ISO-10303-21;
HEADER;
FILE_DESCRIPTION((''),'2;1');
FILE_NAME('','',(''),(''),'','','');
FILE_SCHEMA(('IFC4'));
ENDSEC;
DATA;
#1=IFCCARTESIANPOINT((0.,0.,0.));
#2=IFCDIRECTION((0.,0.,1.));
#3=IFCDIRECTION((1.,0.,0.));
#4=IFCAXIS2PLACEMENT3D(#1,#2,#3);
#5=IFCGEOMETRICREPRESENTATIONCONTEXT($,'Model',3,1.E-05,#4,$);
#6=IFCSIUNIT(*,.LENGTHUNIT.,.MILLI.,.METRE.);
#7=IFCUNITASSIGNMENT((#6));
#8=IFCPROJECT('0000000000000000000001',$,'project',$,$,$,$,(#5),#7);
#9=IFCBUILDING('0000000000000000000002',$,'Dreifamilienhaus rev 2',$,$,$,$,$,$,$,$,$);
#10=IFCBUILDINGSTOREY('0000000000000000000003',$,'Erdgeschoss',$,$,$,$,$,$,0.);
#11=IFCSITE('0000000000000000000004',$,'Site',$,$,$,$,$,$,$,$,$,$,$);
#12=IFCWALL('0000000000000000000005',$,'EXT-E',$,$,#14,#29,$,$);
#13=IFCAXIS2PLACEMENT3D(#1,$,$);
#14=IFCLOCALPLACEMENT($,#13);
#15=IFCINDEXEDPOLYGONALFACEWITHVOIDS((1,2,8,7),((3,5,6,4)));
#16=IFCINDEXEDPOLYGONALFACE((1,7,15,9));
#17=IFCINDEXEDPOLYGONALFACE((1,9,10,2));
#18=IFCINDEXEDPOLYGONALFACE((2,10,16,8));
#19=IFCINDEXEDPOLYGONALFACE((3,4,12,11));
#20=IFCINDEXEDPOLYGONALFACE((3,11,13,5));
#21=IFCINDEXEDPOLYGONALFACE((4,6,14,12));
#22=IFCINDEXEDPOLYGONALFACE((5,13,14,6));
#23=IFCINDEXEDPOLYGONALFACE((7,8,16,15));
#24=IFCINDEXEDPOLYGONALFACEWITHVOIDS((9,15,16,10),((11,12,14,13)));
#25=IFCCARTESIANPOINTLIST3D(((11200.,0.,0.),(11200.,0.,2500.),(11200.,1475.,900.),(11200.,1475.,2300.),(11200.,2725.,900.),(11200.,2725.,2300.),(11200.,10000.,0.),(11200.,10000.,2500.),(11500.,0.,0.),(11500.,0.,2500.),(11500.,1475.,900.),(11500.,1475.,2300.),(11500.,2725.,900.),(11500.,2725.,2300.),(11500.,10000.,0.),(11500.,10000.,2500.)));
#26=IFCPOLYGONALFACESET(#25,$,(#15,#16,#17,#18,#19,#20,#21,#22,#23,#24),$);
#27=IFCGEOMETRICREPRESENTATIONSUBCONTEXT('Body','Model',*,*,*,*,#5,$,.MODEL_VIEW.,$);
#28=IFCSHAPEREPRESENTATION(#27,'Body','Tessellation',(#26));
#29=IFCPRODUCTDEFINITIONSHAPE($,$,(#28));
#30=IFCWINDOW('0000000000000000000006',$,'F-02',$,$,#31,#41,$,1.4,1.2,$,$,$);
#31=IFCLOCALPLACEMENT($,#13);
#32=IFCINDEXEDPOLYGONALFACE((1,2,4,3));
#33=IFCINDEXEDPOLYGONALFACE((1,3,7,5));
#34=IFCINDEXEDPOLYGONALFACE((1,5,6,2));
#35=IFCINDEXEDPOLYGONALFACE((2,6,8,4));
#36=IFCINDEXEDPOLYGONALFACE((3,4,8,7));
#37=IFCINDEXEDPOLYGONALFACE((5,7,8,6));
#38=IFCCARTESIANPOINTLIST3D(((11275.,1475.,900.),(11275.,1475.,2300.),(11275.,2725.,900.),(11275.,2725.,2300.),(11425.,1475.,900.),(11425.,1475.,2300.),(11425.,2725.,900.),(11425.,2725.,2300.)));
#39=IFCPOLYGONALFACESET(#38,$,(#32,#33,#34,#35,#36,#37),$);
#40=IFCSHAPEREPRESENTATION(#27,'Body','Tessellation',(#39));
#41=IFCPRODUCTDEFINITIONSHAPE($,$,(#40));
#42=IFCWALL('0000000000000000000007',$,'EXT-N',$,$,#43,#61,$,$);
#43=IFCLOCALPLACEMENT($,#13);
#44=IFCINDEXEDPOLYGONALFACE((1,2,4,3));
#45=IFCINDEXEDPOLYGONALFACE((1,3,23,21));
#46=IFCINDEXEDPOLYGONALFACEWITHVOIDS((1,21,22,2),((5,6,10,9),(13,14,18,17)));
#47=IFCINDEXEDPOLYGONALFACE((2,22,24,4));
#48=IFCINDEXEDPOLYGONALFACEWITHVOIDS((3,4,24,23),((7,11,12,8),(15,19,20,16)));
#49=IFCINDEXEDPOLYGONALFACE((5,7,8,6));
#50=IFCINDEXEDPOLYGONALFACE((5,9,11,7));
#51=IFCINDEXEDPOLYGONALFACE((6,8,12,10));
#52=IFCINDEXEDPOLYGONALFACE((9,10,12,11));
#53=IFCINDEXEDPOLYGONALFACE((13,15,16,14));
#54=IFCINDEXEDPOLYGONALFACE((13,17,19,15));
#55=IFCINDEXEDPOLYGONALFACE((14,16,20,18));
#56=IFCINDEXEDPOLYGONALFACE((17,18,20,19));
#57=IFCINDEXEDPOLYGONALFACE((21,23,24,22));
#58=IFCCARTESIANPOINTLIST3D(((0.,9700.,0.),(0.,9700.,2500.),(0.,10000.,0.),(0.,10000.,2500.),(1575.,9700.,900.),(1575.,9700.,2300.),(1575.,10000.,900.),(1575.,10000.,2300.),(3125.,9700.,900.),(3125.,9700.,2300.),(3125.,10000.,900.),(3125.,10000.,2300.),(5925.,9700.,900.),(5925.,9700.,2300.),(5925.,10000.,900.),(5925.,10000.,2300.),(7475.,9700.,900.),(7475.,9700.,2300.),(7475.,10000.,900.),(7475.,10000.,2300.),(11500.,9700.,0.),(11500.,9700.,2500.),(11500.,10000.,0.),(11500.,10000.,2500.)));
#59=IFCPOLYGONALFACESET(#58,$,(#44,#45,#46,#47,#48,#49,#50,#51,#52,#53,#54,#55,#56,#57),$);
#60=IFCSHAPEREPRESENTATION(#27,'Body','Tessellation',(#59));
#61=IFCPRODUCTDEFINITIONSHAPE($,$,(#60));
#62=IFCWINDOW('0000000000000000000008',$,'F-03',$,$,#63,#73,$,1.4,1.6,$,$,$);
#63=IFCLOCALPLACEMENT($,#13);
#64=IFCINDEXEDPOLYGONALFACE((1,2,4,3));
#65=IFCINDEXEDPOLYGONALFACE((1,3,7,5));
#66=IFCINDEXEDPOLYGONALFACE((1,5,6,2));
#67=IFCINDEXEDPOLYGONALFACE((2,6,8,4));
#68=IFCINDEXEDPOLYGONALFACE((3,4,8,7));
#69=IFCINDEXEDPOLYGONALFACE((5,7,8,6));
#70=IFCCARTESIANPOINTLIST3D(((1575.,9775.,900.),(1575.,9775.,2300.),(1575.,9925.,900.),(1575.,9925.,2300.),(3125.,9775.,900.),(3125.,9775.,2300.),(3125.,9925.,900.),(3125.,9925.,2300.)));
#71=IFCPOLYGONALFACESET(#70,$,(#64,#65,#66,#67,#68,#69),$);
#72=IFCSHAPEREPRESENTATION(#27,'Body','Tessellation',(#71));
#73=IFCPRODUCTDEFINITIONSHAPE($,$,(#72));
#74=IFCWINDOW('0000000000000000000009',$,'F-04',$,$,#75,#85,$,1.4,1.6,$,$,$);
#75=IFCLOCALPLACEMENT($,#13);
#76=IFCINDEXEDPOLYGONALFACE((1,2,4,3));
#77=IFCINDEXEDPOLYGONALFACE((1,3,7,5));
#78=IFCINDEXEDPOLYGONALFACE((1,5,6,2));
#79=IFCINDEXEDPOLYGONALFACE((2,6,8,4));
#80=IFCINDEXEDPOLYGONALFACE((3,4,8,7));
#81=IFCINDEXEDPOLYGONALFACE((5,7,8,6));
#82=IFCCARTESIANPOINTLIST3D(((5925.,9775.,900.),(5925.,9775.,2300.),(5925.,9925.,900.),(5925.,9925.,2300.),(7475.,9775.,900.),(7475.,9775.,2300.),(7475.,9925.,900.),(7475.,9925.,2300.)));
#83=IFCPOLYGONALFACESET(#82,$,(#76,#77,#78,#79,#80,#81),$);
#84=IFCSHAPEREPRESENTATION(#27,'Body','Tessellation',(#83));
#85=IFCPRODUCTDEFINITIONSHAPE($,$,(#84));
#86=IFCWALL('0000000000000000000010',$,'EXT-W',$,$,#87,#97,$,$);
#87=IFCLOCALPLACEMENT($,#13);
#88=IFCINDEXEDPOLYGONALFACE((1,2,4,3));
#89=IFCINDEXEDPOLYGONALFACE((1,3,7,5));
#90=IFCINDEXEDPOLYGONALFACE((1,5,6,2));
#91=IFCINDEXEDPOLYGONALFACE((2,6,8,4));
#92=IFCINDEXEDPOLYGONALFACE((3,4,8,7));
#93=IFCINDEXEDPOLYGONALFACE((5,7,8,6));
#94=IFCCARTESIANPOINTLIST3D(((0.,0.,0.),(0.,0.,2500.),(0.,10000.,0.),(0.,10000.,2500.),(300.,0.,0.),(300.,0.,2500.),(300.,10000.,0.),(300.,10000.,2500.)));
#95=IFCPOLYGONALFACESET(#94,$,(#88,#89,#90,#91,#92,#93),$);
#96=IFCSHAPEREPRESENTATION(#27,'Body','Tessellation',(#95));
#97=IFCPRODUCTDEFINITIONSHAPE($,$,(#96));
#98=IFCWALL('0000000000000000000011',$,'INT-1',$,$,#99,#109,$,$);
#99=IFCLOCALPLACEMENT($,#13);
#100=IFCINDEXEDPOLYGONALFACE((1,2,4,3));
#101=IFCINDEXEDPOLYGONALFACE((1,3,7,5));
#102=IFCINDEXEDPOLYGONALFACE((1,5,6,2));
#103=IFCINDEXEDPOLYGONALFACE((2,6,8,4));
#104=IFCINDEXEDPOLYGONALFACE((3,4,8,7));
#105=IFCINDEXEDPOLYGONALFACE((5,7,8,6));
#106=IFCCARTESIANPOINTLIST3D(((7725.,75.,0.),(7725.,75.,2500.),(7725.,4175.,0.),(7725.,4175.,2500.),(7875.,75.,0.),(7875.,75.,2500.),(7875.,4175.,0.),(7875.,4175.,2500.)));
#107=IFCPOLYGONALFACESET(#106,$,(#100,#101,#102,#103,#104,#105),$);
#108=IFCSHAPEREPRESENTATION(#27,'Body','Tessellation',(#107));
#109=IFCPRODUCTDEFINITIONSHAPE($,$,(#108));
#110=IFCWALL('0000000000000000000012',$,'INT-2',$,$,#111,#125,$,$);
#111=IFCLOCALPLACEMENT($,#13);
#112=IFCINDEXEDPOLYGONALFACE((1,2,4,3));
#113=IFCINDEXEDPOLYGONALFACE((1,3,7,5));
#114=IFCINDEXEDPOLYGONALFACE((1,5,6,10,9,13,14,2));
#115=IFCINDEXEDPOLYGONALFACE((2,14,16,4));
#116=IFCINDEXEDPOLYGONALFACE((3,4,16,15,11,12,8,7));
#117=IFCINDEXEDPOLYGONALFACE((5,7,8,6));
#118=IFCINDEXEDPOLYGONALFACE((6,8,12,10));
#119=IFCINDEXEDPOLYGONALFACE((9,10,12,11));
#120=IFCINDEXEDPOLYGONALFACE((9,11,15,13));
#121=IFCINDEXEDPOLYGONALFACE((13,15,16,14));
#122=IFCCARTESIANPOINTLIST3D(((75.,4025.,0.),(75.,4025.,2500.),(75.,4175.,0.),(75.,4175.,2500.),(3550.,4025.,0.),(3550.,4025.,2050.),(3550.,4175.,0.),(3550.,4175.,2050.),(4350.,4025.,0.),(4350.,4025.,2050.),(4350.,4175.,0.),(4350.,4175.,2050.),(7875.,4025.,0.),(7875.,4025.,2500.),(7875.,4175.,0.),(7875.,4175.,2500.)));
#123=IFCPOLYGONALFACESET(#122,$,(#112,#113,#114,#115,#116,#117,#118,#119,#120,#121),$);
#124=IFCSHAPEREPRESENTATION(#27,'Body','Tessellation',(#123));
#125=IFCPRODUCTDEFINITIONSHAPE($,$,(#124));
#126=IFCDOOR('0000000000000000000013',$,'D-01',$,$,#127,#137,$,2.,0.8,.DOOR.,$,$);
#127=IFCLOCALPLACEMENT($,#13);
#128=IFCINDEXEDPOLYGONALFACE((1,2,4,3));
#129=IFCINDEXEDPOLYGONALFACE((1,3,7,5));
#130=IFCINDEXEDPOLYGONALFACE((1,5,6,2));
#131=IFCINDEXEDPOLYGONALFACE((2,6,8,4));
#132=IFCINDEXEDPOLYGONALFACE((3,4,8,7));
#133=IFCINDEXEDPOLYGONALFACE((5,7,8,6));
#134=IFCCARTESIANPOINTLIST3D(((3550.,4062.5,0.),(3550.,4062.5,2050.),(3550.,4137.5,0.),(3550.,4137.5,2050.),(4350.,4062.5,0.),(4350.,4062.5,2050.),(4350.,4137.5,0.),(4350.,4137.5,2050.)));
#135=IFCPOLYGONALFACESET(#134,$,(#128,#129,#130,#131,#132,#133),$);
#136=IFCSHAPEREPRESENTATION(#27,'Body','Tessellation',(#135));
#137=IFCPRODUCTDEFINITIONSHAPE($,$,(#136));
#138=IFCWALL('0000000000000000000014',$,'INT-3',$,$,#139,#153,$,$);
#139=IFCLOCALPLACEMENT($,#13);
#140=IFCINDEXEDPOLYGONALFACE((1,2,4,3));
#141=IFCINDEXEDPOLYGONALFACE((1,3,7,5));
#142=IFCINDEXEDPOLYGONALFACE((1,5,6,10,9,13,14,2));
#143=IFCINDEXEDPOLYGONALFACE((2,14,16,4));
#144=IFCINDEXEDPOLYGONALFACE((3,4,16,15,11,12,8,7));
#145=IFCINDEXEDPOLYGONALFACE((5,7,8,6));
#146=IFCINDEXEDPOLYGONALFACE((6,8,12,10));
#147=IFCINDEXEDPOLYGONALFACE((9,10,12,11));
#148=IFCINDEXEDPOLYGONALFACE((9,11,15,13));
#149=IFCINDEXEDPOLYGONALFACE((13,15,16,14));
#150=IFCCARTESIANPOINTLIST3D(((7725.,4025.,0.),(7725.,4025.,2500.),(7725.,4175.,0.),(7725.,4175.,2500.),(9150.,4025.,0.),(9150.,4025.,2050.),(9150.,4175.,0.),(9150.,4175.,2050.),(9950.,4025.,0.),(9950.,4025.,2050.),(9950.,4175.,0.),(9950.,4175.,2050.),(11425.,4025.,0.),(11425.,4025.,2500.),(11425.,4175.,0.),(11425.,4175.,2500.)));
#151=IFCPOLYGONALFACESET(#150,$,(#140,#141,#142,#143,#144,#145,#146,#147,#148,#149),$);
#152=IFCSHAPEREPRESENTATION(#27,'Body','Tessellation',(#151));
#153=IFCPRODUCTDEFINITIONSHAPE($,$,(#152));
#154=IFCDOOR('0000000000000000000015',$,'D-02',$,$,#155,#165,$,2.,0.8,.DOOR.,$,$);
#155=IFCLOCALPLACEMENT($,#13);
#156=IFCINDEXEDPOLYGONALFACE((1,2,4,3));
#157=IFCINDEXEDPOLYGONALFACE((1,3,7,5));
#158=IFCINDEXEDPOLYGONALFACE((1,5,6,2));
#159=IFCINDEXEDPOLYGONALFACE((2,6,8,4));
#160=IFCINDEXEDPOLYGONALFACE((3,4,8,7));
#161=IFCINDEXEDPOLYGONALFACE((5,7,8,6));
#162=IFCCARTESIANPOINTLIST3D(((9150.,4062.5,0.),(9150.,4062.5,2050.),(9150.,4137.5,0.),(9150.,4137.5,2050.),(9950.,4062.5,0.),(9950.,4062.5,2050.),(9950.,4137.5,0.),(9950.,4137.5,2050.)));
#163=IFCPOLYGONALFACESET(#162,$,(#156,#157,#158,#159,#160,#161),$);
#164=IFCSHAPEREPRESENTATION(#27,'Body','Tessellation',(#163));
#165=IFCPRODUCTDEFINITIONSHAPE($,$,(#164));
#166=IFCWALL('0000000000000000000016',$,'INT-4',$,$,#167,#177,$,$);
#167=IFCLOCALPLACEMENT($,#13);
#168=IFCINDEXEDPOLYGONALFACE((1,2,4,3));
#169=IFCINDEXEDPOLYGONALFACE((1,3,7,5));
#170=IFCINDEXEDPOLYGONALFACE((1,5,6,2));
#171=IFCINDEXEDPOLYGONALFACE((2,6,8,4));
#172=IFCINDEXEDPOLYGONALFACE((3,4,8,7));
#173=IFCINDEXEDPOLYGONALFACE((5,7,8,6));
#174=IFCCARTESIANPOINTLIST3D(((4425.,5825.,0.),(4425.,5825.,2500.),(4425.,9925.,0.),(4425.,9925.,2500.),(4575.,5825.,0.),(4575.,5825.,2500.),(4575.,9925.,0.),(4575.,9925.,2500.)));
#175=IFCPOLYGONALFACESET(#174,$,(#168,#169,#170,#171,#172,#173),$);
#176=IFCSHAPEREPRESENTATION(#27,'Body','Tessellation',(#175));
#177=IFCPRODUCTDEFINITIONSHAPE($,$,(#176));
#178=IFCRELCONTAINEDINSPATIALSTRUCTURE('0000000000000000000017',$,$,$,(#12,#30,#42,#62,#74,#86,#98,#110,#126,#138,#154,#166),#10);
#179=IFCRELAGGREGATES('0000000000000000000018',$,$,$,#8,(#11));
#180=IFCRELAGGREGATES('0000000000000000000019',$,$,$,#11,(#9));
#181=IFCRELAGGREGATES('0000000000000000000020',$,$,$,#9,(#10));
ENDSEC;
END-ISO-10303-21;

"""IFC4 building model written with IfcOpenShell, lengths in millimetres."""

from ifc_helpers import new_model, si_unit, frame, origin_with_axes, place, context, subcontext, project, spatial, indexed_curve, outline, extrude, element, fill, save


model = new_model("IFC4")

# Units and contexts
model_context = context("Model", 3, precision=1e-05, world=origin_with_axes())
body_context = subcontext(model_context, "Body", "Model", "MODEL_VIEW")
ifc_project = project(units=[si_unit("LENGTHUNIT", "METRE", prefix="MILLI")], contexts=[model_context])

# Site, building, storey
site = spatial("IfcSite", under=ifc_project, Name="Site")
building = spatial("IfcBuilding", under=site, Name="Dreifamilienhaus rev 2")
storey = spatial("IfcBuildingStorey", under=building, Name="Erdgeschoss", Elevation=0.0)

# Wall, opening, window
wall_1_placement = place(None, origin_with_axes())
wall_1 = element("IfcWall", 1, at=wall_1_placement, inside=storey, Name="EXT-E", context=body_context, shape_type="SweptSolid", body=[
    extrude(outline(indexed_curve([(11200.0, 0.0), (11200.0, 10000.0), (11500.0, 10000.0), (11500.0, 0.0), (11200.0, 0.0)])), origin_with_axes(), (0.0, 0.0, 1.0), 2500.0),
])
opening_1_placement = place(wall_1_placement, frame((0.0, 0.0, 900.0), z_axis=(0.0, 0.0, 1.0), x_axis=(1.0, 0.0, 0.0)))
opening_1 = element("IfcOpeningElement", 2, at=opening_1_placement, cuts=wall_1, context=body_context, shape_type="SweptSolid", body=[
    extrude(outline(indexed_curve([(11180.0, 1475.0), (11180.0, 2725.0), (11520.0, 2725.0), (11520.0, 1475.0), (11180.0, 1475.0)])), origin_with_axes(), (0.0, 0.0, 1.0), 1400.0),
])
window_1_placement = place(opening_1_placement, origin_with_axes())
window_1 = element("IfcWindow", 3, at=window_1_placement, inside=storey, Name="F-02", OverallHeight=1.4, OverallWidth=1.2, context=body_context, shape_type="SweptSolid", body=[
    extrude(outline(indexed_curve([(11275.0, 1475.0), (11275.0, 2725.0), (11425.0, 2725.0), (11425.0, 1475.0), (11275.0, 1475.0)])), origin_with_axes(), (0.0, 0.0, 1.0), 1400.0),
])
fill(opening_1, window_1)

# Wall, openings, windows
wall_2_placement = place(None, origin_with_axes())
wall_2 = element("IfcWall", 4, at=wall_2_placement, inside=storey, Name="EXT-N", context=body_context, shape_type="SweptSolid", body=[
    extrude(outline(indexed_curve([(11500.0, 9700.0), (0.0, 9700.0), (0.0, 10000.0), (11500.0, 10000.0), (11500.0, 9700.0)])), origin_with_axes(), (0.0, 0.0, 1.0), 2500.0),
])
opening_2_placement = place(wall_2_placement, frame((0.0, 0.0, 900.0), z_axis=(0.0, 0.0, 1.0), x_axis=(1.0, 0.0, 0.0)))
opening_2 = element("IfcOpeningElement", 5, at=opening_2_placement, cuts=wall_2, context=body_context, shape_type="SweptSolid", body=[
    extrude(outline(indexed_curve([(3125.0, 9680.0), (1575.0, 9680.0), (1575.0, 10020.0), (3125.0, 10020.0), (3125.0, 9680.0)])), origin_with_axes(), (0.0, 0.0, 1.0), 1400.0),
])
opening_3_placement = place(wall_2_placement, frame((0.0, 0.0, 900.0), z_axis=(0.0, 0.0, 1.0), x_axis=(1.0, 0.0, 0.0)))
opening_3 = element("IfcOpeningElement", 6, at=opening_3_placement, cuts=wall_2, context=body_context, shape_type="SweptSolid", body=[
    extrude(outline(indexed_curve([(7475.0, 9680.0), (5925.0, 9680.0), (5925.0, 10020.0), (7475.0, 10020.0), (7475.0, 9680.0)])), origin_with_axes(), (0.0, 0.0, 1.0), 1400.0),
])
window_2_placement = place(opening_2_placement, origin_with_axes())
window_2 = element("IfcWindow", 7, at=window_2_placement, inside=storey, Name="F-03", OverallHeight=1.4, OverallWidth=1.6, context=body_context, shape_type="SweptSolid", body=[
    extrude(outline(indexed_curve([(3125.0, 9775.0), (1575.0, 9775.0), (1575.0, 9925.0), (3125.0, 9925.0), (3125.0, 9775.0)])), origin_with_axes(), (0.0, 0.0, 1.0), 1400.0),
])
fill(opening_2, window_2)
window_3_placement = place(opening_3_placement, origin_with_axes())
window_3 = element("IfcWindow", 8, at=window_3_placement, inside=storey, Name="F-04", OverallHeight=1.4, OverallWidth=1.6, context=body_context, shape_type="SweptSolid", body=[
    extrude(outline(indexed_curve([(7475.0, 9775.0), (5925.0, 9775.0), (5925.0, 9925.0), (7475.0, 9925.0), (7475.0, 9775.0)])), origin_with_axes(), (0.0, 0.0, 1.0), 1400.0),
])
fill(opening_3, window_3)

# Walls
wall_3_placement = place(None, origin_with_axes())
element("IfcWall", 9, at=wall_3_placement, inside=storey, Name="EXT-W", context=body_context, shape_type="SweptSolid", body=[
    extrude(outline(indexed_curve([(300.0, 10000.0), (300.0, 0.0), (0.0, 0.0), (0.0, 10000.0), (300.0, 10000.0)])), origin_with_axes(), (0.0, 0.0, 1.0), 2500.0),
])
wall_4_placement = place(None, origin_with_axes())
element("IfcWall", 10, at=wall_4_placement, inside=storey, Name="INT-1", context=body_context, shape_type="SweptSolid", body=[
    extrude(outline(indexed_curve([(7725.0, 75.0), (7725.0, 4175.0), (7875.0, 4175.0), (7875.0, 75.0), (7725.0, 75.0)])), origin_with_axes(), (0.0, 0.0, 1.0), 2500.0),
])

# Walls, openings, doors
wall_5_placement = place(None, origin_with_axes())
wall_5 = element("IfcWall", 11, at=wall_5_placement, inside=storey, Name="INT-2", context=body_context, shape_type="SweptSolid", body=[
    extrude(outline(indexed_curve([(75.0, 4175.0), (7875.0, 4175.0), (7875.0, 4025.0), (75.0, 4025.0), (75.0, 4175.0)])), origin_with_axes(), (0.0, 0.0, 1.0), 2500.0),
])
opening_4_placement = place(wall_5_placement, origin_with_axes())
opening_4 = element("IfcOpeningElement", 12, at=opening_4_placement, cuts=wall_5, context=body_context, shape_type="SweptSolid", body=[
    extrude(outline(indexed_curve([(3550.0, 4195.0), (4350.0, 4195.0), (4350.0, 4005.0), (3550.0, 4005.0), (3550.0, 4195.0)])), origin_with_axes(), (0.0, 0.0, 1.0), 2050.0),
])
door_1_placement = place(opening_4_placement, origin_with_axes())
door_1 = element("IfcDoor", 13, at=door_1_placement, inside=storey, Name="D-01", OverallHeight=2.0, OverallWidth=0.8, PredefinedType="DOOR", context=body_context, shape_type="SweptSolid", body=[
    extrude(outline(indexed_curve([(3550.0, 4137.5), (4350.0, 4137.5), (4350.0, 4062.5), (3550.0, 4062.5), (3550.0, 4137.5)])), origin_with_axes(), (0.0, 0.0, 1.0), 2050.0),
])
fill(opening_4, door_1)
wall_6_placement = place(None, origin_with_axes())
wall_6 = element("IfcWall", 14, at=wall_6_placement, inside=storey, Name="INT-3", context=body_context, shape_type="SweptSolid", body=[
    extrude(outline(indexed_curve([(7725.0, 4175.0), (11425.0, 4175.0), (11425.0, 4025.0), (7725.0, 4025.0), (7725.0, 4175.0)])), origin_with_axes(), (0.0, 0.0, 1.0), 2500.0),
])
opening_5_placement = place(wall_6_placement, origin_with_axes())
opening_5 = element("IfcOpeningElement", 15, at=opening_5_placement, cuts=wall_6, context=body_context, shape_type="SweptSolid", body=[
    extrude(outline(indexed_curve([(9150.0, 4195.0), (9950.0, 4195.0), (9950.0, 4005.0), (9150.0, 4005.0), (9150.0, 4195.0)])), origin_with_axes(), (0.0, 0.0, 1.0), 2050.0),
])
door_2_placement = place(opening_5_placement, origin_with_axes())
door_2 = element("IfcDoor", 16, at=door_2_placement, inside=storey, Name="D-02", OverallHeight=2.0, OverallWidth=0.8, PredefinedType="DOOR", context=body_context, shape_type="SweptSolid", body=[
    extrude(outline(indexed_curve([(9150.0, 4137.5), (9950.0, 4137.5), (9950.0, 4062.5), (9150.0, 4062.5), (9150.0, 4137.5)])), origin_with_axes(), (0.0, 0.0, 1.0), 2050.0),
])
fill(opening_5, door_2)

# Wall
wall_7_placement = place(None, origin_with_axes())
element("IfcWall", 17, at=wall_7_placement, inside=storey, Name="INT-4", context=body_context, shape_type="SweptSolid", body=[
    extrude(outline(indexed_curve([(4425.0, 5825.0), (4425.0, 9925.0), (4575.0, 9925.0), (4575.0, 5825.0), (4425.0, 5825.0)])), origin_with_axes(), (0.0, 0.0, 1.0), 2500.0),
])

save(model, "model.ifc")
